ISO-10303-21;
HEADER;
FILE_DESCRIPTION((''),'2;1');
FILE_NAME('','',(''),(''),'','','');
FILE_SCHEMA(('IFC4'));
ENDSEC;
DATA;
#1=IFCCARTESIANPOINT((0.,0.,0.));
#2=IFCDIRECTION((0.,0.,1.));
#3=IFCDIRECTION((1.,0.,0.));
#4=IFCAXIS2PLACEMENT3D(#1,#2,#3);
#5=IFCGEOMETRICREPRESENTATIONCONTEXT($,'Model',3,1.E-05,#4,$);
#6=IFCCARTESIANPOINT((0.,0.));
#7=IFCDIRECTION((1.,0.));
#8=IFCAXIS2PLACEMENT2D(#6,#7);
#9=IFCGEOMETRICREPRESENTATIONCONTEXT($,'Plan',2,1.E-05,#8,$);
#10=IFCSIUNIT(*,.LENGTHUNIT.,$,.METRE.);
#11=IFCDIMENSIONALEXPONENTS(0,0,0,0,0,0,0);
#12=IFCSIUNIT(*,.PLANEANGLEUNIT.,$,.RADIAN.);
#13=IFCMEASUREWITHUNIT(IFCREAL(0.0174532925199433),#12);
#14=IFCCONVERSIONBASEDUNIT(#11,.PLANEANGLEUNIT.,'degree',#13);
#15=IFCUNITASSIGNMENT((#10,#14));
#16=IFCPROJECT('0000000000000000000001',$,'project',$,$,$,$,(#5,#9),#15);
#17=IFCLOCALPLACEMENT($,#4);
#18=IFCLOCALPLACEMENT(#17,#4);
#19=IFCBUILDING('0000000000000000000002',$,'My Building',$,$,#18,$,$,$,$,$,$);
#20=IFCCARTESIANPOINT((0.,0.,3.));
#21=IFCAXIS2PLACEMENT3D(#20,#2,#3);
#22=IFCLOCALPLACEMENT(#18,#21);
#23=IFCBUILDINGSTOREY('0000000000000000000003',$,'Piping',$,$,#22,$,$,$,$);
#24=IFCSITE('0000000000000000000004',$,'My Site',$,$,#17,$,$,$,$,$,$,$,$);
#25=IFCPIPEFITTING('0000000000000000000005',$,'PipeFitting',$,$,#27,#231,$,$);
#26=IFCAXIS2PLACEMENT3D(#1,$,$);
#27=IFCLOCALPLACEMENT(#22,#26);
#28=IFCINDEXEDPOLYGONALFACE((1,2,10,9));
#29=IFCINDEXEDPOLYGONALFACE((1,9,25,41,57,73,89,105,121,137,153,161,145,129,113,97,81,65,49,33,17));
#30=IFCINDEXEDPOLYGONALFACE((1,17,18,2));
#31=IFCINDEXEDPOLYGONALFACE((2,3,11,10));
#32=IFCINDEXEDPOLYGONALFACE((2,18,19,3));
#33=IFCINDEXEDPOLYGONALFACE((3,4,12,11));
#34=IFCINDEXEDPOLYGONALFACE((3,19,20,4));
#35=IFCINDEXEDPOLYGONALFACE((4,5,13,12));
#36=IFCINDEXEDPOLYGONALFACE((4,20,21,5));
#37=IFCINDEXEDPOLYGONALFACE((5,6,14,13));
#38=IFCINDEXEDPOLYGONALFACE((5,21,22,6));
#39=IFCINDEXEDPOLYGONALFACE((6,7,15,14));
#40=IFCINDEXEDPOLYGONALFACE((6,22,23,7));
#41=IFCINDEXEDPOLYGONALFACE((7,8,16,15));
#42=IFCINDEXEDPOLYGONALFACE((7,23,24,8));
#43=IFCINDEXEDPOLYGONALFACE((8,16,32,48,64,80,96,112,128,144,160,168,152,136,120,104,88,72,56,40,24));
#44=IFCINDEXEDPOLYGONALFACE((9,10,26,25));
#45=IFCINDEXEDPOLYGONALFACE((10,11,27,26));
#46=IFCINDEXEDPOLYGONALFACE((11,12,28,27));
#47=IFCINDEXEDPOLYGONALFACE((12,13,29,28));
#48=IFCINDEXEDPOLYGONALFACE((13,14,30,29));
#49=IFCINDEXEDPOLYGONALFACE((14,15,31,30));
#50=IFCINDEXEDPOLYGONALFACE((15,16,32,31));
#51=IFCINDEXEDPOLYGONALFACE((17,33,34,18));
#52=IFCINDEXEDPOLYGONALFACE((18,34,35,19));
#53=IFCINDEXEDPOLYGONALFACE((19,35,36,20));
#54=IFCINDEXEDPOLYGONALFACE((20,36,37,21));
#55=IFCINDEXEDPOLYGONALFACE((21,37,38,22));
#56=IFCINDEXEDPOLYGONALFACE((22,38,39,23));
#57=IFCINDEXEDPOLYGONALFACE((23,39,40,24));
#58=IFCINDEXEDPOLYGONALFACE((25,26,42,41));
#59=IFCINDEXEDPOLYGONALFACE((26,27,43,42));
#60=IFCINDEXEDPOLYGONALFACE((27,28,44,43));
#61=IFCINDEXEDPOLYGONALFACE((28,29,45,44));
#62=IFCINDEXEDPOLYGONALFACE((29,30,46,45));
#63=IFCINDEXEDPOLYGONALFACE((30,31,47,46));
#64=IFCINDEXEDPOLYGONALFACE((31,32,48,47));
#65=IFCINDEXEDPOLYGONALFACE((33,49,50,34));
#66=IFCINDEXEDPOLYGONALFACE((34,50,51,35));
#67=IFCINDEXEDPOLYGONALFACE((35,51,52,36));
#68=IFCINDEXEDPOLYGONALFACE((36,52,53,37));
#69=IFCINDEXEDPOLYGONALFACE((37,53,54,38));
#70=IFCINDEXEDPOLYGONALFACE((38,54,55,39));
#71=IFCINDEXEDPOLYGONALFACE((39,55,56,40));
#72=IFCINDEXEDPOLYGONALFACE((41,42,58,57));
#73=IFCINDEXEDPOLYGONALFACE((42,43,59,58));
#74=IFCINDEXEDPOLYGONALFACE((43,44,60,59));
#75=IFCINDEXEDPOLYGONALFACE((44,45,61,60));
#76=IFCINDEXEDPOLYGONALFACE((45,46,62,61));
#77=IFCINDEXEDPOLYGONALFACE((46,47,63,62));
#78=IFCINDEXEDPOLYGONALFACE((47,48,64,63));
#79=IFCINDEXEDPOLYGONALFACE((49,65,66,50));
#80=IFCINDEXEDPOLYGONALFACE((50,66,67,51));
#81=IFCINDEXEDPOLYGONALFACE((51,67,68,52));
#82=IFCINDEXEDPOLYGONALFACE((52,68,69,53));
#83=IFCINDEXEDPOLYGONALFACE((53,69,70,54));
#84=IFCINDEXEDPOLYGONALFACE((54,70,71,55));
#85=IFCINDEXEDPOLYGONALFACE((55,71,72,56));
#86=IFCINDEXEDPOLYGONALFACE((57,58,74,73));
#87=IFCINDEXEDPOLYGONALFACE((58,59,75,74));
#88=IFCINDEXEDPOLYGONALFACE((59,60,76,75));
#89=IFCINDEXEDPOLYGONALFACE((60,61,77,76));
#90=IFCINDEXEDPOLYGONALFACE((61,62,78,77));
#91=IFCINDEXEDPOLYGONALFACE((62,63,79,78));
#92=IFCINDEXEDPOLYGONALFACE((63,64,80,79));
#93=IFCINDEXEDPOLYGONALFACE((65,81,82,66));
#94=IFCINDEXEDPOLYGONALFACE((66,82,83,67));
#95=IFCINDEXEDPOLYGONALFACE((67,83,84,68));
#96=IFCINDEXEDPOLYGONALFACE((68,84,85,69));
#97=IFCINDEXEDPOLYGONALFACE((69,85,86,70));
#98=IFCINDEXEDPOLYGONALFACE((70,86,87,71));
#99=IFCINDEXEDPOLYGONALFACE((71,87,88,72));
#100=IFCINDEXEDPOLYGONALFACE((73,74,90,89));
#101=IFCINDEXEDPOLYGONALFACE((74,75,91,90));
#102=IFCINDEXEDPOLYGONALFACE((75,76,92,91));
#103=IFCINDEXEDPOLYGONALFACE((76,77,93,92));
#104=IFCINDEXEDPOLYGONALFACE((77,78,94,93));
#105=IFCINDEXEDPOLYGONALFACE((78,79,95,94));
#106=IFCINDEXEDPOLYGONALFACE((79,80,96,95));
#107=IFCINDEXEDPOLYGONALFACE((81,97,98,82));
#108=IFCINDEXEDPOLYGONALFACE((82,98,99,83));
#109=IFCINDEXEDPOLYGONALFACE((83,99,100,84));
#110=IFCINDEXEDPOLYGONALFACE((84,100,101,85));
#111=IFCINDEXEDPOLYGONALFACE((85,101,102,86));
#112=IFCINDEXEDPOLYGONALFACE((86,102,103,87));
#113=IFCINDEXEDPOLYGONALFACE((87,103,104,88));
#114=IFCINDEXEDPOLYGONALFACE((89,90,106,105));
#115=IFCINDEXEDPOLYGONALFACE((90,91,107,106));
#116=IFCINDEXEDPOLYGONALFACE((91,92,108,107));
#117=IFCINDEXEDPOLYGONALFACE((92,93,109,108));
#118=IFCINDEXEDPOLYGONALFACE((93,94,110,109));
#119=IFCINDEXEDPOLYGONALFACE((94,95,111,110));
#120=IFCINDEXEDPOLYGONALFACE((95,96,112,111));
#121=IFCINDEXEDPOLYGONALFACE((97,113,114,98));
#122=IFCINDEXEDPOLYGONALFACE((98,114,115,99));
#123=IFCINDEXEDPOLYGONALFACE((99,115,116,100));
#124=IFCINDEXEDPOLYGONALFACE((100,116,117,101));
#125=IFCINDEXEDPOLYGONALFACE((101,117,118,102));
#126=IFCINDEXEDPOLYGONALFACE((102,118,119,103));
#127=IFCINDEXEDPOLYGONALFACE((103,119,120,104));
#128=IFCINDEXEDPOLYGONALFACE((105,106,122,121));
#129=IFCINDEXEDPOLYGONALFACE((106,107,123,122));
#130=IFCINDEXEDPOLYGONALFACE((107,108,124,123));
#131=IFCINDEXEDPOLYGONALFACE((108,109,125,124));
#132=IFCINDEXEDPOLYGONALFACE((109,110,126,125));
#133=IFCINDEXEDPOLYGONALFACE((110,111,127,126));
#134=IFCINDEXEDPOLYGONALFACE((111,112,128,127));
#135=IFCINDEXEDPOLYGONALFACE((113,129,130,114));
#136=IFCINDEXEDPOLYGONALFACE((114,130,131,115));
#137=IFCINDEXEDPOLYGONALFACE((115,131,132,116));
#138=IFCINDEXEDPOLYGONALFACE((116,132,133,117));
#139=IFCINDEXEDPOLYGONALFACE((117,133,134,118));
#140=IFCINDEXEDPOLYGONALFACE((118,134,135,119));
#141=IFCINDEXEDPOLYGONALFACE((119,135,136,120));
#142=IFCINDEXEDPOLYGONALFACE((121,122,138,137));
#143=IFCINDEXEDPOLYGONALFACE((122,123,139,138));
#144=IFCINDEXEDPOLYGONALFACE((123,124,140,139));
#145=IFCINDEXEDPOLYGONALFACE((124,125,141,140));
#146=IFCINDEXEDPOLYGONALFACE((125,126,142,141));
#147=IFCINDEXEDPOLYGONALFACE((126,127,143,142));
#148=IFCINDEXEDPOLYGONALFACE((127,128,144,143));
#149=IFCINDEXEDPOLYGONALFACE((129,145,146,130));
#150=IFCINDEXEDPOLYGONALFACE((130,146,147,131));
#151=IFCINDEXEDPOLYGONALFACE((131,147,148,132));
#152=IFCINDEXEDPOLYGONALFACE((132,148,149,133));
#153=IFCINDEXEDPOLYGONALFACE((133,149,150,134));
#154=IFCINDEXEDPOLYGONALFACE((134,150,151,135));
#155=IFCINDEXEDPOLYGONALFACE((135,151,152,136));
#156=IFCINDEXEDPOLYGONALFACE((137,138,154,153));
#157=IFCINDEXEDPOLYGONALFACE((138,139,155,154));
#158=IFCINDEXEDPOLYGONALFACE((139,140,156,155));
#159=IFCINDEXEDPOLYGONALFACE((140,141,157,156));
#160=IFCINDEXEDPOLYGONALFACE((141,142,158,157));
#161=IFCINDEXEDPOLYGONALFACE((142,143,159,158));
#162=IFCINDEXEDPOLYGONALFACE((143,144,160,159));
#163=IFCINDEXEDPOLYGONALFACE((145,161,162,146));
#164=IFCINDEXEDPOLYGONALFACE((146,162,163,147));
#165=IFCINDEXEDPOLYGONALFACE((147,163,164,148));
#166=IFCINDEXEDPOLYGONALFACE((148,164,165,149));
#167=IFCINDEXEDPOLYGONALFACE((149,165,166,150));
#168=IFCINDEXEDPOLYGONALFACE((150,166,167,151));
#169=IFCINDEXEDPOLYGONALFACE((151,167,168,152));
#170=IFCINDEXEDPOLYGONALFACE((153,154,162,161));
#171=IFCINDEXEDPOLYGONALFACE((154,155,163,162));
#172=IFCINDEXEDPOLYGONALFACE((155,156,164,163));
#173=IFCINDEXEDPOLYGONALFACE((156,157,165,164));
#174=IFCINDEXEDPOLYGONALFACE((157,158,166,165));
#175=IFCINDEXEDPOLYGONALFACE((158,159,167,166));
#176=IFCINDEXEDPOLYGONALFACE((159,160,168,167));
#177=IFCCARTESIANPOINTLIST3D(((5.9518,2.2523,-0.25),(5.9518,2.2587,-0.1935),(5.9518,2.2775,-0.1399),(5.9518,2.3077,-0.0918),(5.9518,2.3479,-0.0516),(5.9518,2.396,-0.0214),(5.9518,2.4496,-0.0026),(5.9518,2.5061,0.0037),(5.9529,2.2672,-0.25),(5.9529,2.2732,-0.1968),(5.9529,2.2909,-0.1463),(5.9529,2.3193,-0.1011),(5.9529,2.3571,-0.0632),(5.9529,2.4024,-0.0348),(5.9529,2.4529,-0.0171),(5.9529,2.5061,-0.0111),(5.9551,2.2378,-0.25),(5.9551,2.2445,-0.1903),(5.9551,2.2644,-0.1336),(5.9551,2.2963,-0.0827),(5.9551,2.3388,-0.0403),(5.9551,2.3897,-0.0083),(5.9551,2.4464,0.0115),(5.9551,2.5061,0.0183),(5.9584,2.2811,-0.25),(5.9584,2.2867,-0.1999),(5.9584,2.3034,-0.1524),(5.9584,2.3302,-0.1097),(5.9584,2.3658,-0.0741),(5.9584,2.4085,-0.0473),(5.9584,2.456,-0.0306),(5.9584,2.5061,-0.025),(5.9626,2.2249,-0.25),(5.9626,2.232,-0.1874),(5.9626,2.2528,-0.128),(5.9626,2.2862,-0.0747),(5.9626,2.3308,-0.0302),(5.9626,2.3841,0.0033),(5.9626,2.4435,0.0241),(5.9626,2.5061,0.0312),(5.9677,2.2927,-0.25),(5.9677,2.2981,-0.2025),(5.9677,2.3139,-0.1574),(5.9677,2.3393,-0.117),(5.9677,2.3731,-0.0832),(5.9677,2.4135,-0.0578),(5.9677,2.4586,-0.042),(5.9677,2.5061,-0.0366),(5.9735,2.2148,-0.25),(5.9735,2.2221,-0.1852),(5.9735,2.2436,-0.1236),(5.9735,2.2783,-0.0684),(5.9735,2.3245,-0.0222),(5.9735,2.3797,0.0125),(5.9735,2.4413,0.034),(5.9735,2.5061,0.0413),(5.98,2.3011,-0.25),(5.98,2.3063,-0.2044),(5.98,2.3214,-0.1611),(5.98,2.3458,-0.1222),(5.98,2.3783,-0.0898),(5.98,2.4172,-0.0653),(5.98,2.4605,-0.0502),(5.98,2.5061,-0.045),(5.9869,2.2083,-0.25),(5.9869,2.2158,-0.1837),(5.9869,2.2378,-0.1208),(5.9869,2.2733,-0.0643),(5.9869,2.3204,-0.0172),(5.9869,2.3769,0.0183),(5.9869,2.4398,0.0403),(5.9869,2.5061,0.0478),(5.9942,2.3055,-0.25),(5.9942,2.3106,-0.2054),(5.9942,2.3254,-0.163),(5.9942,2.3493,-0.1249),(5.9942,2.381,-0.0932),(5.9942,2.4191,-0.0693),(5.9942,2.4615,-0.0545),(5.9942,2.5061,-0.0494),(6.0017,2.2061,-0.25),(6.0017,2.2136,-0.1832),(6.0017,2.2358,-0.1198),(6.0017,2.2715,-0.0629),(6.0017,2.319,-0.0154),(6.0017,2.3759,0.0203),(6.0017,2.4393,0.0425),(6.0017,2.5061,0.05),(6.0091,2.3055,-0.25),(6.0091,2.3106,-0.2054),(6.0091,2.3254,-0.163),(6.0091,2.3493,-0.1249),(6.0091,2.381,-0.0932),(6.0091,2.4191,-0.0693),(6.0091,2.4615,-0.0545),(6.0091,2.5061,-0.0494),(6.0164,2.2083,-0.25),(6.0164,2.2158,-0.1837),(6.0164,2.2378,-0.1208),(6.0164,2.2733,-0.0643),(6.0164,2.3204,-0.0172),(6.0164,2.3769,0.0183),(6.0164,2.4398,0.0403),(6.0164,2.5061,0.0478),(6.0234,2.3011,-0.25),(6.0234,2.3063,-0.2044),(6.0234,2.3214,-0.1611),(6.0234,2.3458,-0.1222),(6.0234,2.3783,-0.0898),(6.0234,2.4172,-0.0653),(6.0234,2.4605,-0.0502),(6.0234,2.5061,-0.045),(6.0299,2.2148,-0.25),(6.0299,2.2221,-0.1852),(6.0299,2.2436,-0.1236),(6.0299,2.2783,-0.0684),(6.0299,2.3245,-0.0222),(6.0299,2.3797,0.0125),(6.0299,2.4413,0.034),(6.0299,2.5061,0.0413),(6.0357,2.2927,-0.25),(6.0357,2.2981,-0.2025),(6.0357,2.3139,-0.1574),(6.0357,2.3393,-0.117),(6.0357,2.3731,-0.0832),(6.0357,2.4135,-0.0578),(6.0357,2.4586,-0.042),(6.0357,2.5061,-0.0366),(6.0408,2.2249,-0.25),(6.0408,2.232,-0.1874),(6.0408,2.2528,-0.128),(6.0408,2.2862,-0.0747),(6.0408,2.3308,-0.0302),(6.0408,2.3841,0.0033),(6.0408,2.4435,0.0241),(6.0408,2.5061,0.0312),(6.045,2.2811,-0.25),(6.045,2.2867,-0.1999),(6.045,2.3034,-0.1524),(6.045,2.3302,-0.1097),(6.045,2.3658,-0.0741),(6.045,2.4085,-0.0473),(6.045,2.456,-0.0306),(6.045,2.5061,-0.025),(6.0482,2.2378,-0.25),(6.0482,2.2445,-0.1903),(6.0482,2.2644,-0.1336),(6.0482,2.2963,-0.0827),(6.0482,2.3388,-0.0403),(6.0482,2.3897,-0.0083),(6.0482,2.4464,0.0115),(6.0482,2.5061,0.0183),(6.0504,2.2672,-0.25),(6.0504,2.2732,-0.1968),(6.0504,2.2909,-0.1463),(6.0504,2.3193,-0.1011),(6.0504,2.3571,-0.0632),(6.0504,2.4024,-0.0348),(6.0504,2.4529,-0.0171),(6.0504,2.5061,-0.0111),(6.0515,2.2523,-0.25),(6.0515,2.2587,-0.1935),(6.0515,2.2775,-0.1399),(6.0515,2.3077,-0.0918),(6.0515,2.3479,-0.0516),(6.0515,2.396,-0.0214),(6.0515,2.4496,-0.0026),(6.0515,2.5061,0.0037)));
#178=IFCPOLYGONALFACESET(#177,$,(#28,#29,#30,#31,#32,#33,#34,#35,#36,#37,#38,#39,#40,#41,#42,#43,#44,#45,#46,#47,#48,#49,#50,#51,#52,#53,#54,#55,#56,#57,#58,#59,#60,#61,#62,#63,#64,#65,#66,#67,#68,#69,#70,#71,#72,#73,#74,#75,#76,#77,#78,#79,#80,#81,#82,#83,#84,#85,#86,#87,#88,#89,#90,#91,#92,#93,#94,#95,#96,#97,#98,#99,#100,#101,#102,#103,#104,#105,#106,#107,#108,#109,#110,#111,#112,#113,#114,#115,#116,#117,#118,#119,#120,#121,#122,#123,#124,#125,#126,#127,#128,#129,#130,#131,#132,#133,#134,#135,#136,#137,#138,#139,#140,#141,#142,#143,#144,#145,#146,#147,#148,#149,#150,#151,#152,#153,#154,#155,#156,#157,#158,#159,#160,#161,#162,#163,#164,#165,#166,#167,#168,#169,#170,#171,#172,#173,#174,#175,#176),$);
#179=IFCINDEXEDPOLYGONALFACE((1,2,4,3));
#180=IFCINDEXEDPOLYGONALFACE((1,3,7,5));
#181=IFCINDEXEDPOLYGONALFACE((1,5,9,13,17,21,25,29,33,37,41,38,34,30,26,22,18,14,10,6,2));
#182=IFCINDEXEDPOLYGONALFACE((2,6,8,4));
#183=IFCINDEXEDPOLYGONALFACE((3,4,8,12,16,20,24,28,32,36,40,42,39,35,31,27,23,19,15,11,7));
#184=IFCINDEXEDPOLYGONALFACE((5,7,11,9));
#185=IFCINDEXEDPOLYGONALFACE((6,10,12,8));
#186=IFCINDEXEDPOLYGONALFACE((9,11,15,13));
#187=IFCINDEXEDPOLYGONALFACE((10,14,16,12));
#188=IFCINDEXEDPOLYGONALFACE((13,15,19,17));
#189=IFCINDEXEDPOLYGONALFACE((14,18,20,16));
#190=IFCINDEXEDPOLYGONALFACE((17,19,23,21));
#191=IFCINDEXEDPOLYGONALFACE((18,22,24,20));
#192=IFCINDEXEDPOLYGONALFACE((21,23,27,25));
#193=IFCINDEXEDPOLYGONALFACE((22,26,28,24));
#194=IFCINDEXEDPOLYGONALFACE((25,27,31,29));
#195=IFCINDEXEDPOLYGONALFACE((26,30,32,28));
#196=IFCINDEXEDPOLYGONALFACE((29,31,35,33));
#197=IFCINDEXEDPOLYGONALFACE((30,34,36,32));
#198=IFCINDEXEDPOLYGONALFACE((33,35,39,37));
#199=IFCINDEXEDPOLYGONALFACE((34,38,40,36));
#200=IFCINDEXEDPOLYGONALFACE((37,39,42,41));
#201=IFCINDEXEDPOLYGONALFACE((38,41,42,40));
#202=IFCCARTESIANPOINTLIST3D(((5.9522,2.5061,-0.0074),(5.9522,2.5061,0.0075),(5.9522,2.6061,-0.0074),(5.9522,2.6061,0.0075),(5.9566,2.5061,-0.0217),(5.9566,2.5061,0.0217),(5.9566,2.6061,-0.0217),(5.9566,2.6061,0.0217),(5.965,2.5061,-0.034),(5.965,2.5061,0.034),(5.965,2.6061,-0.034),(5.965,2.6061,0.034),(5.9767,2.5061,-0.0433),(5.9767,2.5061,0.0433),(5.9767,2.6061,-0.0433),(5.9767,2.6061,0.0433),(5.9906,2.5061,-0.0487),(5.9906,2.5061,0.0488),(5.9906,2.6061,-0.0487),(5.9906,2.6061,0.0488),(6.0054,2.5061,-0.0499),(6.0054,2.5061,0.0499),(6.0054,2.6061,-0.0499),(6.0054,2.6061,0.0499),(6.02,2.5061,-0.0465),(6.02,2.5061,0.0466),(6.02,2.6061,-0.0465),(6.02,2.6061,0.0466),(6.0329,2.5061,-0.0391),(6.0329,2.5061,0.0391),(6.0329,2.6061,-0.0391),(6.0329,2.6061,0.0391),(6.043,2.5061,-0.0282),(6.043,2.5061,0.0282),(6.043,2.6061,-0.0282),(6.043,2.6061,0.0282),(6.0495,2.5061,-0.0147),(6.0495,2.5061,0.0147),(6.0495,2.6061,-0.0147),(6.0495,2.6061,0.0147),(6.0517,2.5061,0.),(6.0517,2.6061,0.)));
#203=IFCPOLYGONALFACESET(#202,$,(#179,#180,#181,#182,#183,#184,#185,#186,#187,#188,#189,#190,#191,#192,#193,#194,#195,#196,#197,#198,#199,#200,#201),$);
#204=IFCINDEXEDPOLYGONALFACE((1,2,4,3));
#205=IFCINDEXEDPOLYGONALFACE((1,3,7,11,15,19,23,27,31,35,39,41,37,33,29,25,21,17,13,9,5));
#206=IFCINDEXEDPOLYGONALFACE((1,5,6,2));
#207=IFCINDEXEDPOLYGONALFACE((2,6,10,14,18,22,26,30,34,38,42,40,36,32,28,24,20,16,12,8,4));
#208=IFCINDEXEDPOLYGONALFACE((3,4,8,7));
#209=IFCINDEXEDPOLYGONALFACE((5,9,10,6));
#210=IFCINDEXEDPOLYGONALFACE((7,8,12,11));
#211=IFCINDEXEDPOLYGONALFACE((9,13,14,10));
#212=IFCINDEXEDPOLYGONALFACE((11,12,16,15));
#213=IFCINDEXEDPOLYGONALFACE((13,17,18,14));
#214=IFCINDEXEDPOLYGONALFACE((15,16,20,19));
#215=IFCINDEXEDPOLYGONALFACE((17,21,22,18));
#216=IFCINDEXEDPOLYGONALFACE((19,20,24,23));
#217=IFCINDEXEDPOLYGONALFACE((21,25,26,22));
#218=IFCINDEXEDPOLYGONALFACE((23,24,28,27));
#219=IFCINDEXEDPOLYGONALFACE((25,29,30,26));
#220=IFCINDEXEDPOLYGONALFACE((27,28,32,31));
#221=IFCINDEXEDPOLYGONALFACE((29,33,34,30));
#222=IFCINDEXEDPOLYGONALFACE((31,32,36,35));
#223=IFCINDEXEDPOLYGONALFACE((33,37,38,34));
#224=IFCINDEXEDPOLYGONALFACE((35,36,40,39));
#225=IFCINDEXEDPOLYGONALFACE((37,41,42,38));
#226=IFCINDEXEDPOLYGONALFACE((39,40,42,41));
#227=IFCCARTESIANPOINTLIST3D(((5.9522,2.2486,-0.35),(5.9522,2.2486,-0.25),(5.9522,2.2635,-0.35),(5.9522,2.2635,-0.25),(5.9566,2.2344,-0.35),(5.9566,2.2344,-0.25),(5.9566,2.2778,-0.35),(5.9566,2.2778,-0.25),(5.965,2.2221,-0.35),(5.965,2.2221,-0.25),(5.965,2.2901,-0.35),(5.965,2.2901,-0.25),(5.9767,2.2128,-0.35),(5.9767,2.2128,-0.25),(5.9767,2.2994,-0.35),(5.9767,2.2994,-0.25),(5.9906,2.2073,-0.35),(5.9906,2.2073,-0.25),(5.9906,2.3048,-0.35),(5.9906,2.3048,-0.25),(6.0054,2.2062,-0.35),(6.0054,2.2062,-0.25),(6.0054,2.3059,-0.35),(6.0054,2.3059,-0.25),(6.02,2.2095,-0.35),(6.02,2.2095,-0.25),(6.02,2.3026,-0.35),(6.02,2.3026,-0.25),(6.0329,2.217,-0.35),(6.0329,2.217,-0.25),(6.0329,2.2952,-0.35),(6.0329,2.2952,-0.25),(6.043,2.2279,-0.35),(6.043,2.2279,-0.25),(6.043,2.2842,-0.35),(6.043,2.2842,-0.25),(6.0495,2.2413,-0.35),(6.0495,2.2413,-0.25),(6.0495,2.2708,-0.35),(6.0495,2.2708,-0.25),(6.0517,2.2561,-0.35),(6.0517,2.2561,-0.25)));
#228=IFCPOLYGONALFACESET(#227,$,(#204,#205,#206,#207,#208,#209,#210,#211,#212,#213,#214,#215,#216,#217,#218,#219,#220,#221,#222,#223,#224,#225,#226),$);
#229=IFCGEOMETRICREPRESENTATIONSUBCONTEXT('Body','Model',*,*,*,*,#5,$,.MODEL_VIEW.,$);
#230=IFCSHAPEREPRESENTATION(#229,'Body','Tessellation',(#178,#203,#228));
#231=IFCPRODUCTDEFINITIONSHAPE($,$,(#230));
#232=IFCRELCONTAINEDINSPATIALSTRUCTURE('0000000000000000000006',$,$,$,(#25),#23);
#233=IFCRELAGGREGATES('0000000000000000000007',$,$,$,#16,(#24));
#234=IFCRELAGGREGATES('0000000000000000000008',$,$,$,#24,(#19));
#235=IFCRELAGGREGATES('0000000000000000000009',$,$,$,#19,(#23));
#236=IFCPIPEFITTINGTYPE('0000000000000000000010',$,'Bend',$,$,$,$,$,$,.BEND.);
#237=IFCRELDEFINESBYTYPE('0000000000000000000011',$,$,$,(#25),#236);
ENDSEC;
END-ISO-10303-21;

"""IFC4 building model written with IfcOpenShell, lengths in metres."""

from ifc_helpers import new_model, entity, si_unit, converted_unit, frame, origin_with_axes, origin_2d_with_axis, place, context, subcontext, project, spatial, circle, extrude, source, transform, mapped, type_object, type_shapes, element, save


model = new_model("IFC4")

# Units and contexts
model_context = context("Model", 3, precision=1e-05, world=origin_with_axes())
plan_context = context("Plan", 2, precision=1e-05, world=origin_2d_with_axis())
body_context = subcontext(model_context, "Body", "Model", "MODEL_VIEW")
ifc_project = project(units=[si_unit("LENGTHUNIT", "METRE"), converted_unit("PLANEANGLEUNIT", "degree", entity("IfcReal", 0.0174532925199433), si_unit("PLANEANGLEUNIT", "RADIAN"), dimensions=[0, 0, 0, 0, 0, 0, 0])], contexts=[model_context, plan_context])

# Site, building, storey
site_placement = place(None, origin_with_axes())
site = spatial("IfcSite", under=ifc_project, at=site_placement, Name="My Site")
building_placement = place(site_placement, origin_with_axes())
building = spatial("IfcBuilding", under=site, at=building_placement, Name="My Building")
storey_placement = place(building_placement, frame((0.0, 0.0, 3.0), z_axis=(0.0, 0.0, 1.0), x_axis=(1.0, 0.0, 0.0)))
storey = spatial("IfcBuildingStorey", under=building, at=storey_placement, Name="Piping")

# Pipe fitting
pipe_fitting_type = type_object("IfcPipeFittingType", Name="Bend", PredefinedType="BEND")
shared_shape = source(origin_with_axes(), body_context, "Body", "SolidModel", [
    entity("IfcSweptDiskSolid", entity("IfcIndexedPolyCurve", entity("IfcCartesianPointList3D", [[0.0, 0.0, 0.1], [0.0, -0.0732, 0.2768], [0.0, -0.25, 0.35]]), [entity("IfcArcIndex", [1, 2, 3])]), 0.05),
    extrude(circle(Radius=0.05), origin_with_axes(), (0.0, 0.0, 1.0), 0.1),
    extrude(circle(Radius=0.05), frame((0.0, -0.25, 0.35), z_axis=(0.0, -1.0, 0.0), x_axis=(1.0, 0.0, 0.0)), (0.0, 0.0, 1.0), 0.1),
])
type_shapes(pipe_fitting_type, [shared_shape])
for number, where, z_axis, x_axis, name in (
    (1, (6.0017, 2.6061, 0.0), (0.0, -1.0, 0.0), (1.0, 0.0, 0.0), "PipeFitting"),
):
    element("IfcPipeFitting", number, at=place(storey_placement, frame(where, z_axis=z_axis, x_axis=x_axis)), inside=storey, type_object=pipe_fitting_type, Name=name, context=body_context, shape_type="MappedRepresentation", body=[
        mapped(shared_shape, transform((0.0, 0.0, 0.0), x_axis=(1.0, 0.0, 0.0), y_axis=(0.0, 1.0, 0.0), z_axis=(0.0, 0.0, 1.0), scale=1.0)),
    ])

save(model, "model.ifc")
